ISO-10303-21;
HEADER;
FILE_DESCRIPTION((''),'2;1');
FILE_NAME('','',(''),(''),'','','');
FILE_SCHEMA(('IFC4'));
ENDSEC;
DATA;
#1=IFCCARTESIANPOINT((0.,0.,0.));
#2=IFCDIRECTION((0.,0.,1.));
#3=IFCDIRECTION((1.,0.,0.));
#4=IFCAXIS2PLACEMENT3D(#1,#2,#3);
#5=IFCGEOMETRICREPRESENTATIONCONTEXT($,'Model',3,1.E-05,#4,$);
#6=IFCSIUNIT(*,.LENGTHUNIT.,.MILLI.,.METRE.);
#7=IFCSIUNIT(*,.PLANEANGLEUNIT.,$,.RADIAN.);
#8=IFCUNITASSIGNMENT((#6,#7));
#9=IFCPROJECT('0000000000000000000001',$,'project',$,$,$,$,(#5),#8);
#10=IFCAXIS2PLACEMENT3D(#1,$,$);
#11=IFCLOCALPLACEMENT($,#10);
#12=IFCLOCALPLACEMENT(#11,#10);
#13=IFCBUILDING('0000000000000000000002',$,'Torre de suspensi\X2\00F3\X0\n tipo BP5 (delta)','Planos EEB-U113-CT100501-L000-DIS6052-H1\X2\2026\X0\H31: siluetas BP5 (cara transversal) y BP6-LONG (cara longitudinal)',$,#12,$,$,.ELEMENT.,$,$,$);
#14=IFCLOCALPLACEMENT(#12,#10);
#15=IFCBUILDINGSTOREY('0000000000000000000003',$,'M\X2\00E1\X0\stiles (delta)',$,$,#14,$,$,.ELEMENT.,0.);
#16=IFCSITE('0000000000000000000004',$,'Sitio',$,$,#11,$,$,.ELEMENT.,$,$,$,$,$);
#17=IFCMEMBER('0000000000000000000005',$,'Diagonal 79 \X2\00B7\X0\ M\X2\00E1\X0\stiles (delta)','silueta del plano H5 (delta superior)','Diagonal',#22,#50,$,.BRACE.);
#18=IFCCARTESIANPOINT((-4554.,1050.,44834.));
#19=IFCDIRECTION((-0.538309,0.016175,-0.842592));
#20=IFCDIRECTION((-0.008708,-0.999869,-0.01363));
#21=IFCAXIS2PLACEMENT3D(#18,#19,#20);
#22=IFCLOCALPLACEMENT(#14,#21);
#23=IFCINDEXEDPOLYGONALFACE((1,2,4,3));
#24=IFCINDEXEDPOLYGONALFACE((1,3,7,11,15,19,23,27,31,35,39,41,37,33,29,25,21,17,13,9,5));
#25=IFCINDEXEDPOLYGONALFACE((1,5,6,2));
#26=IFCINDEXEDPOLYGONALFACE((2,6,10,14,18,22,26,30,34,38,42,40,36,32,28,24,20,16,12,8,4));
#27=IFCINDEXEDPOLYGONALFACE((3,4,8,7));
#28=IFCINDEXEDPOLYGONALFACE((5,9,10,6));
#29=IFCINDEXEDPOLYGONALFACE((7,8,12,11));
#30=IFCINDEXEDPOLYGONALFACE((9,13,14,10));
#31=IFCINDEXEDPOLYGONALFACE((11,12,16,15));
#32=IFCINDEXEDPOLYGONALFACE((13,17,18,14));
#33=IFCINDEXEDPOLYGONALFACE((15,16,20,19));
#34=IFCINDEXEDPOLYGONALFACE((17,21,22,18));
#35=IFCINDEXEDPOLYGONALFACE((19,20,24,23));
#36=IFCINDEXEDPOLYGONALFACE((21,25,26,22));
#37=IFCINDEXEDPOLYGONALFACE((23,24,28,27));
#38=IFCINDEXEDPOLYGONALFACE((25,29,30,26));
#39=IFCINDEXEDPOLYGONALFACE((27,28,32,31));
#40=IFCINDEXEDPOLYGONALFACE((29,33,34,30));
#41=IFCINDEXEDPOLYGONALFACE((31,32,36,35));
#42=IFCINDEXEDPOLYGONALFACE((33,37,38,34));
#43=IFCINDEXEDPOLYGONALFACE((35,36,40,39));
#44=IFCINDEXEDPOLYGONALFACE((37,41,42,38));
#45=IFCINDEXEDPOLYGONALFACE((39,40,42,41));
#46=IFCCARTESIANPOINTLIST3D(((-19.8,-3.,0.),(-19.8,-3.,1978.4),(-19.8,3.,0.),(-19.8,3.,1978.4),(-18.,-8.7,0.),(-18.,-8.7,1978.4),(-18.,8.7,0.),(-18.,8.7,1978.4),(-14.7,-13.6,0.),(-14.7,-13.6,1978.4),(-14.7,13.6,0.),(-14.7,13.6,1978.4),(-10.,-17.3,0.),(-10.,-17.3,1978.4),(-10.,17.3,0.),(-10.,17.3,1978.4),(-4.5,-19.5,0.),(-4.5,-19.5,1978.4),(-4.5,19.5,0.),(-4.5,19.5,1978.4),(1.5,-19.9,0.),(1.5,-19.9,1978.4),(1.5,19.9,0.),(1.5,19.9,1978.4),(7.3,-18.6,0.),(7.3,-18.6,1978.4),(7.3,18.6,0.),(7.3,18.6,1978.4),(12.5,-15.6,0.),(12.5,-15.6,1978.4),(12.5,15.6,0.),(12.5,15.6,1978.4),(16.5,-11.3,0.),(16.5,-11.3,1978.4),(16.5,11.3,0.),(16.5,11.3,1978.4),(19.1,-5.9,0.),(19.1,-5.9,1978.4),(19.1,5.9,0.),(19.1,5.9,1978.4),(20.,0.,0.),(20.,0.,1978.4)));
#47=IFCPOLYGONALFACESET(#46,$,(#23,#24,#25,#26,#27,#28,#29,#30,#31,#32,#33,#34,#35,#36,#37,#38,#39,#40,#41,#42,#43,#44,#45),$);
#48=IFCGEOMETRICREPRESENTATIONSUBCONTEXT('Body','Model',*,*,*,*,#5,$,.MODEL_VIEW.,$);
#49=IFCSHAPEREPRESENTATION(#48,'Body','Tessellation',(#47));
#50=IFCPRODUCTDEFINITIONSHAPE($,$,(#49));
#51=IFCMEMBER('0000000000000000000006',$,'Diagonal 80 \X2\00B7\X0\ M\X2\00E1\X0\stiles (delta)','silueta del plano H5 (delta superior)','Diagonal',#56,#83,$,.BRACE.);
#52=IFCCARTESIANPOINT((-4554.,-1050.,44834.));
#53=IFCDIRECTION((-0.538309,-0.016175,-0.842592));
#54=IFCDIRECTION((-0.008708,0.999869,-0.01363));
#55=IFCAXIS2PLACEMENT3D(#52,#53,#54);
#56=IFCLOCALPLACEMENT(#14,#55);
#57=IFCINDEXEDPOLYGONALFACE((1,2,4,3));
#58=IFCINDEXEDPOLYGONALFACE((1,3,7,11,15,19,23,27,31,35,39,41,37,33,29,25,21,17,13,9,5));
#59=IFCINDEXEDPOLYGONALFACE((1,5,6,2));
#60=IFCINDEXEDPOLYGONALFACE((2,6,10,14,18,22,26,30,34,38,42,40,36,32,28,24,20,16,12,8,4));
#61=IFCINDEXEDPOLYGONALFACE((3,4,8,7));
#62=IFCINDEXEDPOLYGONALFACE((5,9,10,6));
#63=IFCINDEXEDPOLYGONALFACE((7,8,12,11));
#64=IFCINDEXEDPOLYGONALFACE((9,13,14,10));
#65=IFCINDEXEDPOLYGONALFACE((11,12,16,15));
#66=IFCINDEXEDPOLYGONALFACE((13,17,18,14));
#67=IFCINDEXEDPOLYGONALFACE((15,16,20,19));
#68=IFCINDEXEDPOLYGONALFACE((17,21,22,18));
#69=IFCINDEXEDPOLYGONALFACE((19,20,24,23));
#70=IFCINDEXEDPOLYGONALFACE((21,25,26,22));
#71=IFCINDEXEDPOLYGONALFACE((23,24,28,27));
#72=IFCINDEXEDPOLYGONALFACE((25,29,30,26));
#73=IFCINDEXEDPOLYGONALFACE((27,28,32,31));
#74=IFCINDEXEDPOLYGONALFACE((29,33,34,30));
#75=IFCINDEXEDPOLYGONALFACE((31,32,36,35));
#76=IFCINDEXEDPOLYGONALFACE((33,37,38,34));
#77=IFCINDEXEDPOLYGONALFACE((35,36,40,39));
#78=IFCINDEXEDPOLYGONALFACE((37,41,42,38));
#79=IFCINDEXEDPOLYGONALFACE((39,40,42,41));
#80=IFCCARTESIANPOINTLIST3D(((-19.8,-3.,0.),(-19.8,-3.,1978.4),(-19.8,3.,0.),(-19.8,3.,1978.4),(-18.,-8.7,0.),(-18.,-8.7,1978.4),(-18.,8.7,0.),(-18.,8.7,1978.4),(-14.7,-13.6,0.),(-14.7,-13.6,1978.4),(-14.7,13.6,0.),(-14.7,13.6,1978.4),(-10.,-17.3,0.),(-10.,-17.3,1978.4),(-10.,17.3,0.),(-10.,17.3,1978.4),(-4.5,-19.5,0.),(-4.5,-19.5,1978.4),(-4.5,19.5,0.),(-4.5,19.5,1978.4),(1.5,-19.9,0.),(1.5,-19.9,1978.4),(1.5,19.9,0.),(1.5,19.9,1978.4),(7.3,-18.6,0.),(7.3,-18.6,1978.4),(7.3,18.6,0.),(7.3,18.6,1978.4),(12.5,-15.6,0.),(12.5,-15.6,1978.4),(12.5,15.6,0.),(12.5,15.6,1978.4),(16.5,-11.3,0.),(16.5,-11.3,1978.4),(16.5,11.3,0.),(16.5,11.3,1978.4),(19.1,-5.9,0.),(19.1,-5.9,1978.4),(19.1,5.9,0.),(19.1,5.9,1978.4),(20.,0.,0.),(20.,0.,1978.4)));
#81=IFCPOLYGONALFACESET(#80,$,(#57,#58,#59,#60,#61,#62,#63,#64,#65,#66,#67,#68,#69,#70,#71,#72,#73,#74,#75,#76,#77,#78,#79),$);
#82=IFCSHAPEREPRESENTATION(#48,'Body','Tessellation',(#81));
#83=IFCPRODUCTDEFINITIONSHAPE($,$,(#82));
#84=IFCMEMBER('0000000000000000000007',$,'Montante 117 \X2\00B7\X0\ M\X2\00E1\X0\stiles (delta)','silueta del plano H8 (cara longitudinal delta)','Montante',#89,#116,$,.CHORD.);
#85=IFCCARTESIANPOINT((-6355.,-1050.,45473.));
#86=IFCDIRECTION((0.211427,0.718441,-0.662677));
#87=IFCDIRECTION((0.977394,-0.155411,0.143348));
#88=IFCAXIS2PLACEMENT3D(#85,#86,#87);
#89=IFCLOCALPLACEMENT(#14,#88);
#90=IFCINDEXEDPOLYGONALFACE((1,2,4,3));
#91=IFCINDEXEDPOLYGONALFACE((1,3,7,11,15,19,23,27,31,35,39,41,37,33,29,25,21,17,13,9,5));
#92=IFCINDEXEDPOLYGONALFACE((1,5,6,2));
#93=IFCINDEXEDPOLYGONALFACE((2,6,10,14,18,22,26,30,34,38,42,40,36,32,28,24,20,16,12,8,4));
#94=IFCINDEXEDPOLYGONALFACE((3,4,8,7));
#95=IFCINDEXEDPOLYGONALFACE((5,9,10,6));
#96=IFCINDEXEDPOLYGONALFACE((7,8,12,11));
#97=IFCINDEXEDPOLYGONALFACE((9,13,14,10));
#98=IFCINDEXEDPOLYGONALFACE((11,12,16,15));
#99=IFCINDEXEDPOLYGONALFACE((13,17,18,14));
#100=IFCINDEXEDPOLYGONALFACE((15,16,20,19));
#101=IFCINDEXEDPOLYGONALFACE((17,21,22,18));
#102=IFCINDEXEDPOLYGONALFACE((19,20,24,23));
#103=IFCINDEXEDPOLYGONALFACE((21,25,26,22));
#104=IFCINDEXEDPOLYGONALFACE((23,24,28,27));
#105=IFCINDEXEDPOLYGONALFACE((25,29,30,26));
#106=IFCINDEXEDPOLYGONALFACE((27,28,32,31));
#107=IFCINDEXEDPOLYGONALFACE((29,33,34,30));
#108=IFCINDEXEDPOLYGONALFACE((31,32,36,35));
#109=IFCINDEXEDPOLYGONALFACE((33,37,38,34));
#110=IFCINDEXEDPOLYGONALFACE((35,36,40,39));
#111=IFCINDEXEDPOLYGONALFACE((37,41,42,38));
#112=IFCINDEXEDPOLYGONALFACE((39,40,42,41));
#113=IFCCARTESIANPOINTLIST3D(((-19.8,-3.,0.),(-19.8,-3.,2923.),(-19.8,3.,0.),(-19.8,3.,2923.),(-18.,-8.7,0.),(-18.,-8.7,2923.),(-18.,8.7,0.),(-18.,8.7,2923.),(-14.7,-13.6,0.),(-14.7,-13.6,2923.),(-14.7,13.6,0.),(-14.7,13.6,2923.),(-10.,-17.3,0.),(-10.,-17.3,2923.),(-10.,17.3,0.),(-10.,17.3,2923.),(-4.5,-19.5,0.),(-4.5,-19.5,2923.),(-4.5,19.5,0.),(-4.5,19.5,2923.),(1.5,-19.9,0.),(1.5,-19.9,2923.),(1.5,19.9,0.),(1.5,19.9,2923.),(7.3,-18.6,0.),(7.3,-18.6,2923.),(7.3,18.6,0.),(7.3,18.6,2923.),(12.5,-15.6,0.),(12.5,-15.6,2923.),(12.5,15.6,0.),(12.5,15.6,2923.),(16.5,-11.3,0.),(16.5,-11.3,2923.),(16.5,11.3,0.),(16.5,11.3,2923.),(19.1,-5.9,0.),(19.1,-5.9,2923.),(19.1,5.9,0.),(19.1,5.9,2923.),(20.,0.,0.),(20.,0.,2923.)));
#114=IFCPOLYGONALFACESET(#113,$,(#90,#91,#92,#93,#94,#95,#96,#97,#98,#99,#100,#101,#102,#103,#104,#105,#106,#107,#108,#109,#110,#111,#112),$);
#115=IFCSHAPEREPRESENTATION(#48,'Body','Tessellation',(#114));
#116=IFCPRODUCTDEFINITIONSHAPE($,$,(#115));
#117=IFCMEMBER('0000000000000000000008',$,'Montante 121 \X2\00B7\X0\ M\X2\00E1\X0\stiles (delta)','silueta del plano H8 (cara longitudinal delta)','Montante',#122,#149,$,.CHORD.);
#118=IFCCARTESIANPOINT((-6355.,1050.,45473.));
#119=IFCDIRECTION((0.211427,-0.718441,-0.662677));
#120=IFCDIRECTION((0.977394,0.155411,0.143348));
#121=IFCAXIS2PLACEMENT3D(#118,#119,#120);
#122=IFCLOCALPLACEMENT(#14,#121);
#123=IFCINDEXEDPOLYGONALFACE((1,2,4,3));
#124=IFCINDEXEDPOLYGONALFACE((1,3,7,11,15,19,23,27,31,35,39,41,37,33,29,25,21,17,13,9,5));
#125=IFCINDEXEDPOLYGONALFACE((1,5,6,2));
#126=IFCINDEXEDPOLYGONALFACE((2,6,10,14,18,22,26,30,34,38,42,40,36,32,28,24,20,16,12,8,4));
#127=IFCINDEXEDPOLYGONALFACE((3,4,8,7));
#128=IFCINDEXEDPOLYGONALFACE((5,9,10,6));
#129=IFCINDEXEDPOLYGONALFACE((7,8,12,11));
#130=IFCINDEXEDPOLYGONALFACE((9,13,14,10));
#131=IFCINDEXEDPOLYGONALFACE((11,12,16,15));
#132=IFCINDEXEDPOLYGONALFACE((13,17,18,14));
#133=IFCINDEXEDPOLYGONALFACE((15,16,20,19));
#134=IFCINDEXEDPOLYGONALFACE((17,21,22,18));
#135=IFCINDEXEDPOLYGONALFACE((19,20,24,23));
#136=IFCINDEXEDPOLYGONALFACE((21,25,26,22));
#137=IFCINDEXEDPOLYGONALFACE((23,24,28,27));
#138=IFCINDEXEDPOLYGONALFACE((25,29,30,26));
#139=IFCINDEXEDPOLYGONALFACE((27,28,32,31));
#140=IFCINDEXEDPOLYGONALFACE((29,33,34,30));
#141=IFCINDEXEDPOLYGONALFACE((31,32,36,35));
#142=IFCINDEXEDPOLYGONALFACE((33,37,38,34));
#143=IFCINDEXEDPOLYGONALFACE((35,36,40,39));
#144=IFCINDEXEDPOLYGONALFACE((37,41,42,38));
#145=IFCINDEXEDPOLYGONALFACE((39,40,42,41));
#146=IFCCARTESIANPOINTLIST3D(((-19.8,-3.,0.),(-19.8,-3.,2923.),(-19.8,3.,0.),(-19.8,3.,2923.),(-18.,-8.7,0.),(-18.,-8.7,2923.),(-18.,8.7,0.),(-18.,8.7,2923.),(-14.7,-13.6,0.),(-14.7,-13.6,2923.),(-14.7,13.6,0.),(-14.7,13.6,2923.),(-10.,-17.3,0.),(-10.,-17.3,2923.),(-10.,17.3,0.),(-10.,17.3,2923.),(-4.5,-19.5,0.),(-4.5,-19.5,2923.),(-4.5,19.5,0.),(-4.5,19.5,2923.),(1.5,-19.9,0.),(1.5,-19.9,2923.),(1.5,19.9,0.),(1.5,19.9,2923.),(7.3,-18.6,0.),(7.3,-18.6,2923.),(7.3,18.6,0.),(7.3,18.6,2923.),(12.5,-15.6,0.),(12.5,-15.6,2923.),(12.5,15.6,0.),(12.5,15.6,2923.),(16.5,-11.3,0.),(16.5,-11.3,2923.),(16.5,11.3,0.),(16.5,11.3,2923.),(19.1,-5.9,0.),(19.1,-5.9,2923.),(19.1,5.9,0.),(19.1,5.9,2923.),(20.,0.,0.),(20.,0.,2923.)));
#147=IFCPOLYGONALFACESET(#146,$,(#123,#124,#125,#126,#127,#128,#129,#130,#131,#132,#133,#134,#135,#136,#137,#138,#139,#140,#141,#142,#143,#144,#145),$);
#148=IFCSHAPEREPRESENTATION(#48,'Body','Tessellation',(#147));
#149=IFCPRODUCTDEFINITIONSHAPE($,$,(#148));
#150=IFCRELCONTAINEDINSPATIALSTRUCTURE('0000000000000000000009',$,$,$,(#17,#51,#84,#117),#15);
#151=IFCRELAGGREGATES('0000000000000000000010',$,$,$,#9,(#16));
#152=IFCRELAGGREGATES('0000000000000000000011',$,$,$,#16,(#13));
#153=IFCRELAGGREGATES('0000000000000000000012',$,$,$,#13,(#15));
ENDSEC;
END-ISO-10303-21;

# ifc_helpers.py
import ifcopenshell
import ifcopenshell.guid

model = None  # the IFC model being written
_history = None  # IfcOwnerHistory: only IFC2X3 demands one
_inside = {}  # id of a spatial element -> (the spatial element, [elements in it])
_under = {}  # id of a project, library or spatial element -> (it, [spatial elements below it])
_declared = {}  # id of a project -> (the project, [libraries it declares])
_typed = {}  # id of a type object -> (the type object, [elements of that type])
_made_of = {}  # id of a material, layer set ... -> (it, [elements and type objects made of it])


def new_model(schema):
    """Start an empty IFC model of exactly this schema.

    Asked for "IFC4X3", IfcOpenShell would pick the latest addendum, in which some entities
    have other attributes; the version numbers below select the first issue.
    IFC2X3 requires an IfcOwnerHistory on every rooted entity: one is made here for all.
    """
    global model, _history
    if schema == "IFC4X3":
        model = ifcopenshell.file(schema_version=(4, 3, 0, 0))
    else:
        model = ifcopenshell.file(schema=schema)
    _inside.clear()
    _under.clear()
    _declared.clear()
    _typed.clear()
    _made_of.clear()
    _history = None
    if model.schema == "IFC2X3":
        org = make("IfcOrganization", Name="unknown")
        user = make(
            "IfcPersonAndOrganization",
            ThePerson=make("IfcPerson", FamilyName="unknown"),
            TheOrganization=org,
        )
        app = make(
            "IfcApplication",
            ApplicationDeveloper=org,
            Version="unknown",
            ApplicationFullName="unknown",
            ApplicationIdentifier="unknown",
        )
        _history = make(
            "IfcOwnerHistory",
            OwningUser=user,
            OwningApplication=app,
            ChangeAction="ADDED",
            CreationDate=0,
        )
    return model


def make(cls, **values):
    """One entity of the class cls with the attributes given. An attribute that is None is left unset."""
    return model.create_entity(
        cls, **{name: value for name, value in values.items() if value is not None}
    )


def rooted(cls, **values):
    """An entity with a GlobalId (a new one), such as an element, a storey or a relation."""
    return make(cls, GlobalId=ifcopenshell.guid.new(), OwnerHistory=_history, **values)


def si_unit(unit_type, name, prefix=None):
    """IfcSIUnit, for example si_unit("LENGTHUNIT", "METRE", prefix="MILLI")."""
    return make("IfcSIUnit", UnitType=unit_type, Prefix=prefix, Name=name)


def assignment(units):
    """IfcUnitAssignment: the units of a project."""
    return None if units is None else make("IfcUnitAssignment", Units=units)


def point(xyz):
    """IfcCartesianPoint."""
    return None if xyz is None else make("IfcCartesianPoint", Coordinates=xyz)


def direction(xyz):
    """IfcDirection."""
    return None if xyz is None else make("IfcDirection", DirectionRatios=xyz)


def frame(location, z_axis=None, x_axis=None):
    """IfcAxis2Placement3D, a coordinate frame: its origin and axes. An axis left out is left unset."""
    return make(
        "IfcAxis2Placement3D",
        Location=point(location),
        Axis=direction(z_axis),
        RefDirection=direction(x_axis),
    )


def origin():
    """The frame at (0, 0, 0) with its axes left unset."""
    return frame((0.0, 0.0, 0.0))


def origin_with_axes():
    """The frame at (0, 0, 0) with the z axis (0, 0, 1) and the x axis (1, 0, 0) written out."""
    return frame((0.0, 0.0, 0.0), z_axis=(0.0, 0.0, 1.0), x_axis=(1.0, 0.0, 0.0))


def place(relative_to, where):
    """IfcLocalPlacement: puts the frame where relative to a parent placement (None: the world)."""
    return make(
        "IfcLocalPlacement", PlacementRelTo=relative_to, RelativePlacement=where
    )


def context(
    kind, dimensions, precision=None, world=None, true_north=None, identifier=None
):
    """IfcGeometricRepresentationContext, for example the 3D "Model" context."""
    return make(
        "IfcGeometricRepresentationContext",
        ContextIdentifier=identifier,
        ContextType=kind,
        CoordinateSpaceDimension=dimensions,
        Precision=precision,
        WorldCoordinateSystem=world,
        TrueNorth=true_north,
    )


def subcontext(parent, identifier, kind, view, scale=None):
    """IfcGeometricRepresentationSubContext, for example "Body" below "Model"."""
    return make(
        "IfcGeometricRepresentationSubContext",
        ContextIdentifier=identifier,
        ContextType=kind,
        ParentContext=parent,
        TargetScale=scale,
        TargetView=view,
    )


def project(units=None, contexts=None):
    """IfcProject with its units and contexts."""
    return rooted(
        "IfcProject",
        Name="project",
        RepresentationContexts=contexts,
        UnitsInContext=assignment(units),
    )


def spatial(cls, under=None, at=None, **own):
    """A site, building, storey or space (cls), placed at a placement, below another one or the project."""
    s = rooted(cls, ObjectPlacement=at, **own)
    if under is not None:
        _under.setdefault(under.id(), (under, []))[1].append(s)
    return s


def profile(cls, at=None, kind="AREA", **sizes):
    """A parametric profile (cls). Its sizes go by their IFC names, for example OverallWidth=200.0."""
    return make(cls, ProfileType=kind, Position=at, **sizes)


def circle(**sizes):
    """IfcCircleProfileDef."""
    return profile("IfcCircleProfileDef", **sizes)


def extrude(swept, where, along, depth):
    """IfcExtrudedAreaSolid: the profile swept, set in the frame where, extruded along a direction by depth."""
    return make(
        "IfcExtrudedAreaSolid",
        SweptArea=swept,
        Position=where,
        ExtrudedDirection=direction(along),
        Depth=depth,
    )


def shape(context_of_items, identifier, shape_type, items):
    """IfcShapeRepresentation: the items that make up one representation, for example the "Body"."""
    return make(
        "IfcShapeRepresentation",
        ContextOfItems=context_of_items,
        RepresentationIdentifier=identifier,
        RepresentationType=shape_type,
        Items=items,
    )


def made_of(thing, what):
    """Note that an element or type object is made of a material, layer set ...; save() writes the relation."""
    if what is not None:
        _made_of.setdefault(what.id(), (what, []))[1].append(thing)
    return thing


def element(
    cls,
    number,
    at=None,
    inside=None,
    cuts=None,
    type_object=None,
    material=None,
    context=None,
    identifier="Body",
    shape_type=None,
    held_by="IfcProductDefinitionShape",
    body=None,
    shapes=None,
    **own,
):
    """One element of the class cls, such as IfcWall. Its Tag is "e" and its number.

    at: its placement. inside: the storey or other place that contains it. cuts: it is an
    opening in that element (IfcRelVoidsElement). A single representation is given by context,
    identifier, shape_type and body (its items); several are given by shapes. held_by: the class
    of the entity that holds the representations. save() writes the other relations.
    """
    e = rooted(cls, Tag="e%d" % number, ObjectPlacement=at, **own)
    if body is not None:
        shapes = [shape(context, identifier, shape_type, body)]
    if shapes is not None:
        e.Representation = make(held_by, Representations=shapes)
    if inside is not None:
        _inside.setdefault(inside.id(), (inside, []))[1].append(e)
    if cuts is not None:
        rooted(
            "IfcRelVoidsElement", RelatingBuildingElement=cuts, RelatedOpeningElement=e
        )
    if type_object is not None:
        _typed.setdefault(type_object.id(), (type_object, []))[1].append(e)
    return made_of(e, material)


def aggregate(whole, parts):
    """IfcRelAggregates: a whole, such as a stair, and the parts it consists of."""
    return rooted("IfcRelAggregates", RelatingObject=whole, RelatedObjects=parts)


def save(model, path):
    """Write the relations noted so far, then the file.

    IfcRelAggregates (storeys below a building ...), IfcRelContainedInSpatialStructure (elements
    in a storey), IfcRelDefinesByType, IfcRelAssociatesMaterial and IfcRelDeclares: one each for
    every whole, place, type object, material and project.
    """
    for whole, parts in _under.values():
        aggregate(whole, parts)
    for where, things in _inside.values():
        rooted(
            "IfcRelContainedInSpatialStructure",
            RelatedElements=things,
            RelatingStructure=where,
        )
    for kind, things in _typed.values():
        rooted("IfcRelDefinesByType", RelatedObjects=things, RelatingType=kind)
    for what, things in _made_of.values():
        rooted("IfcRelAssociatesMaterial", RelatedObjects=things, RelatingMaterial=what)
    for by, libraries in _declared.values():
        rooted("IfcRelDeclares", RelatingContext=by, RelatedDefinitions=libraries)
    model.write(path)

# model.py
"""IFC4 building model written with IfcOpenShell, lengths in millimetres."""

from ifc_helpers import new_model, si_unit, frame, origin, origin_with_axes, place, context, subcontext, project, spatial, circle, extrude, element, save


model = new_model("IFC4")

# Units and contexts
model_context = context("Model", 3, precision=1e-05, world=origin_with_axes())
body_context = subcontext(model_context, "Body", "Model", "MODEL_VIEW")
ifc_project = project(units=[si_unit("LENGTHUNIT", "METRE", prefix="MILLI"), si_unit("PLANEANGLEUNIT", "RADIAN")], contexts=[model_context])

# Site, building, storey
site_placement = place(None, origin())
site = spatial("IfcSite", under=ifc_project, at=site_placement, Name="Sitio", CompositionType="ELEMENT")
building_placement = place(site_placement, origin())
building = spatial("IfcBuilding", under=site, at=building_placement, Name="Torre de suspensión tipo BP5 (delta)", Description="Planos EEB-U113-CT100501-L000-DIS6052-H1…H31: siluetas BP5 (cara transversal) y BP6-LONG (cara longitudinal)", CompositionType="ELEMENT")
storey_placement = place(building_placement, origin())
storey = spatial("IfcBuildingStorey", under=building, at=storey_placement, Name="Mástiles (delta)", CompositionType="ELEMENT", Elevation=0.0)

# Members
for number, where, z_axis, x_axis, name in (
    (1, (-4554.0, 1050.0, 44834.0), (-0.538309, 0.016175, -0.842592), (-0.008708, -0.999869, -0.01363), "Diagonal 79 · Mástiles (delta)"),
    (2, (-4554.0, -1050.0, 44834.0), (-0.538309, -0.016175, -0.842592), (-0.008708, 0.999869, -0.01363), "Diagonal 80 · Mástiles (delta)"),
):
    element("IfcMember", number, at=place(storey_placement, frame(where, z_axis=z_axis, x_axis=x_axis)), inside=storey, Name=name, Description="silueta del plano H5 (delta superior)", ObjectType="Diagonal", PredefinedType="BRACE", context=body_context, shape_type="SweptSolid", body=[
        extrude(circle(Radius=20.0), None, (0.0, 0.0, 1.0), 1978.4),
    ])
member_1_placement = place(storey_placement, frame((-6355.0, -1050.0, 45473.0), z_axis=(0.211427, 0.718441, -0.662677), x_axis=(0.977394, -0.155411, 0.143348)))
element("IfcMember", 3, at=member_1_placement, inside=storey, Name="Montante 117 · Mástiles (delta)", Description="silueta del plano H8 (cara longitudinal delta)", ObjectType="Montante", PredefinedType="CHORD", context=body_context, shape_type="SweptSolid", body=[
    extrude(circle(Radius=20.0), None, (0.0, 0.0, 1.0), 2923.0),
])
member_2_placement = place(storey_placement, frame((-6355.0, 1050.0, 45473.0), z_axis=(0.211427, -0.718441, -0.662677), x_axis=(0.977394, 0.155411, 0.143348)))
element("IfcMember", 4, at=member_2_placement, inside=storey, Name="Montante 121 · Mástiles (delta)", Description="silueta del plano H8 (cara longitudinal delta)", ObjectType="Montante", PredefinedType="CHORD", context=body_context, shape_type="SweptSolid", body=[
    extrude(circle(Radius=20.0), None, (0.0, 0.0, 1.0), 2923.0),
])

save(model, "model.ifc")
